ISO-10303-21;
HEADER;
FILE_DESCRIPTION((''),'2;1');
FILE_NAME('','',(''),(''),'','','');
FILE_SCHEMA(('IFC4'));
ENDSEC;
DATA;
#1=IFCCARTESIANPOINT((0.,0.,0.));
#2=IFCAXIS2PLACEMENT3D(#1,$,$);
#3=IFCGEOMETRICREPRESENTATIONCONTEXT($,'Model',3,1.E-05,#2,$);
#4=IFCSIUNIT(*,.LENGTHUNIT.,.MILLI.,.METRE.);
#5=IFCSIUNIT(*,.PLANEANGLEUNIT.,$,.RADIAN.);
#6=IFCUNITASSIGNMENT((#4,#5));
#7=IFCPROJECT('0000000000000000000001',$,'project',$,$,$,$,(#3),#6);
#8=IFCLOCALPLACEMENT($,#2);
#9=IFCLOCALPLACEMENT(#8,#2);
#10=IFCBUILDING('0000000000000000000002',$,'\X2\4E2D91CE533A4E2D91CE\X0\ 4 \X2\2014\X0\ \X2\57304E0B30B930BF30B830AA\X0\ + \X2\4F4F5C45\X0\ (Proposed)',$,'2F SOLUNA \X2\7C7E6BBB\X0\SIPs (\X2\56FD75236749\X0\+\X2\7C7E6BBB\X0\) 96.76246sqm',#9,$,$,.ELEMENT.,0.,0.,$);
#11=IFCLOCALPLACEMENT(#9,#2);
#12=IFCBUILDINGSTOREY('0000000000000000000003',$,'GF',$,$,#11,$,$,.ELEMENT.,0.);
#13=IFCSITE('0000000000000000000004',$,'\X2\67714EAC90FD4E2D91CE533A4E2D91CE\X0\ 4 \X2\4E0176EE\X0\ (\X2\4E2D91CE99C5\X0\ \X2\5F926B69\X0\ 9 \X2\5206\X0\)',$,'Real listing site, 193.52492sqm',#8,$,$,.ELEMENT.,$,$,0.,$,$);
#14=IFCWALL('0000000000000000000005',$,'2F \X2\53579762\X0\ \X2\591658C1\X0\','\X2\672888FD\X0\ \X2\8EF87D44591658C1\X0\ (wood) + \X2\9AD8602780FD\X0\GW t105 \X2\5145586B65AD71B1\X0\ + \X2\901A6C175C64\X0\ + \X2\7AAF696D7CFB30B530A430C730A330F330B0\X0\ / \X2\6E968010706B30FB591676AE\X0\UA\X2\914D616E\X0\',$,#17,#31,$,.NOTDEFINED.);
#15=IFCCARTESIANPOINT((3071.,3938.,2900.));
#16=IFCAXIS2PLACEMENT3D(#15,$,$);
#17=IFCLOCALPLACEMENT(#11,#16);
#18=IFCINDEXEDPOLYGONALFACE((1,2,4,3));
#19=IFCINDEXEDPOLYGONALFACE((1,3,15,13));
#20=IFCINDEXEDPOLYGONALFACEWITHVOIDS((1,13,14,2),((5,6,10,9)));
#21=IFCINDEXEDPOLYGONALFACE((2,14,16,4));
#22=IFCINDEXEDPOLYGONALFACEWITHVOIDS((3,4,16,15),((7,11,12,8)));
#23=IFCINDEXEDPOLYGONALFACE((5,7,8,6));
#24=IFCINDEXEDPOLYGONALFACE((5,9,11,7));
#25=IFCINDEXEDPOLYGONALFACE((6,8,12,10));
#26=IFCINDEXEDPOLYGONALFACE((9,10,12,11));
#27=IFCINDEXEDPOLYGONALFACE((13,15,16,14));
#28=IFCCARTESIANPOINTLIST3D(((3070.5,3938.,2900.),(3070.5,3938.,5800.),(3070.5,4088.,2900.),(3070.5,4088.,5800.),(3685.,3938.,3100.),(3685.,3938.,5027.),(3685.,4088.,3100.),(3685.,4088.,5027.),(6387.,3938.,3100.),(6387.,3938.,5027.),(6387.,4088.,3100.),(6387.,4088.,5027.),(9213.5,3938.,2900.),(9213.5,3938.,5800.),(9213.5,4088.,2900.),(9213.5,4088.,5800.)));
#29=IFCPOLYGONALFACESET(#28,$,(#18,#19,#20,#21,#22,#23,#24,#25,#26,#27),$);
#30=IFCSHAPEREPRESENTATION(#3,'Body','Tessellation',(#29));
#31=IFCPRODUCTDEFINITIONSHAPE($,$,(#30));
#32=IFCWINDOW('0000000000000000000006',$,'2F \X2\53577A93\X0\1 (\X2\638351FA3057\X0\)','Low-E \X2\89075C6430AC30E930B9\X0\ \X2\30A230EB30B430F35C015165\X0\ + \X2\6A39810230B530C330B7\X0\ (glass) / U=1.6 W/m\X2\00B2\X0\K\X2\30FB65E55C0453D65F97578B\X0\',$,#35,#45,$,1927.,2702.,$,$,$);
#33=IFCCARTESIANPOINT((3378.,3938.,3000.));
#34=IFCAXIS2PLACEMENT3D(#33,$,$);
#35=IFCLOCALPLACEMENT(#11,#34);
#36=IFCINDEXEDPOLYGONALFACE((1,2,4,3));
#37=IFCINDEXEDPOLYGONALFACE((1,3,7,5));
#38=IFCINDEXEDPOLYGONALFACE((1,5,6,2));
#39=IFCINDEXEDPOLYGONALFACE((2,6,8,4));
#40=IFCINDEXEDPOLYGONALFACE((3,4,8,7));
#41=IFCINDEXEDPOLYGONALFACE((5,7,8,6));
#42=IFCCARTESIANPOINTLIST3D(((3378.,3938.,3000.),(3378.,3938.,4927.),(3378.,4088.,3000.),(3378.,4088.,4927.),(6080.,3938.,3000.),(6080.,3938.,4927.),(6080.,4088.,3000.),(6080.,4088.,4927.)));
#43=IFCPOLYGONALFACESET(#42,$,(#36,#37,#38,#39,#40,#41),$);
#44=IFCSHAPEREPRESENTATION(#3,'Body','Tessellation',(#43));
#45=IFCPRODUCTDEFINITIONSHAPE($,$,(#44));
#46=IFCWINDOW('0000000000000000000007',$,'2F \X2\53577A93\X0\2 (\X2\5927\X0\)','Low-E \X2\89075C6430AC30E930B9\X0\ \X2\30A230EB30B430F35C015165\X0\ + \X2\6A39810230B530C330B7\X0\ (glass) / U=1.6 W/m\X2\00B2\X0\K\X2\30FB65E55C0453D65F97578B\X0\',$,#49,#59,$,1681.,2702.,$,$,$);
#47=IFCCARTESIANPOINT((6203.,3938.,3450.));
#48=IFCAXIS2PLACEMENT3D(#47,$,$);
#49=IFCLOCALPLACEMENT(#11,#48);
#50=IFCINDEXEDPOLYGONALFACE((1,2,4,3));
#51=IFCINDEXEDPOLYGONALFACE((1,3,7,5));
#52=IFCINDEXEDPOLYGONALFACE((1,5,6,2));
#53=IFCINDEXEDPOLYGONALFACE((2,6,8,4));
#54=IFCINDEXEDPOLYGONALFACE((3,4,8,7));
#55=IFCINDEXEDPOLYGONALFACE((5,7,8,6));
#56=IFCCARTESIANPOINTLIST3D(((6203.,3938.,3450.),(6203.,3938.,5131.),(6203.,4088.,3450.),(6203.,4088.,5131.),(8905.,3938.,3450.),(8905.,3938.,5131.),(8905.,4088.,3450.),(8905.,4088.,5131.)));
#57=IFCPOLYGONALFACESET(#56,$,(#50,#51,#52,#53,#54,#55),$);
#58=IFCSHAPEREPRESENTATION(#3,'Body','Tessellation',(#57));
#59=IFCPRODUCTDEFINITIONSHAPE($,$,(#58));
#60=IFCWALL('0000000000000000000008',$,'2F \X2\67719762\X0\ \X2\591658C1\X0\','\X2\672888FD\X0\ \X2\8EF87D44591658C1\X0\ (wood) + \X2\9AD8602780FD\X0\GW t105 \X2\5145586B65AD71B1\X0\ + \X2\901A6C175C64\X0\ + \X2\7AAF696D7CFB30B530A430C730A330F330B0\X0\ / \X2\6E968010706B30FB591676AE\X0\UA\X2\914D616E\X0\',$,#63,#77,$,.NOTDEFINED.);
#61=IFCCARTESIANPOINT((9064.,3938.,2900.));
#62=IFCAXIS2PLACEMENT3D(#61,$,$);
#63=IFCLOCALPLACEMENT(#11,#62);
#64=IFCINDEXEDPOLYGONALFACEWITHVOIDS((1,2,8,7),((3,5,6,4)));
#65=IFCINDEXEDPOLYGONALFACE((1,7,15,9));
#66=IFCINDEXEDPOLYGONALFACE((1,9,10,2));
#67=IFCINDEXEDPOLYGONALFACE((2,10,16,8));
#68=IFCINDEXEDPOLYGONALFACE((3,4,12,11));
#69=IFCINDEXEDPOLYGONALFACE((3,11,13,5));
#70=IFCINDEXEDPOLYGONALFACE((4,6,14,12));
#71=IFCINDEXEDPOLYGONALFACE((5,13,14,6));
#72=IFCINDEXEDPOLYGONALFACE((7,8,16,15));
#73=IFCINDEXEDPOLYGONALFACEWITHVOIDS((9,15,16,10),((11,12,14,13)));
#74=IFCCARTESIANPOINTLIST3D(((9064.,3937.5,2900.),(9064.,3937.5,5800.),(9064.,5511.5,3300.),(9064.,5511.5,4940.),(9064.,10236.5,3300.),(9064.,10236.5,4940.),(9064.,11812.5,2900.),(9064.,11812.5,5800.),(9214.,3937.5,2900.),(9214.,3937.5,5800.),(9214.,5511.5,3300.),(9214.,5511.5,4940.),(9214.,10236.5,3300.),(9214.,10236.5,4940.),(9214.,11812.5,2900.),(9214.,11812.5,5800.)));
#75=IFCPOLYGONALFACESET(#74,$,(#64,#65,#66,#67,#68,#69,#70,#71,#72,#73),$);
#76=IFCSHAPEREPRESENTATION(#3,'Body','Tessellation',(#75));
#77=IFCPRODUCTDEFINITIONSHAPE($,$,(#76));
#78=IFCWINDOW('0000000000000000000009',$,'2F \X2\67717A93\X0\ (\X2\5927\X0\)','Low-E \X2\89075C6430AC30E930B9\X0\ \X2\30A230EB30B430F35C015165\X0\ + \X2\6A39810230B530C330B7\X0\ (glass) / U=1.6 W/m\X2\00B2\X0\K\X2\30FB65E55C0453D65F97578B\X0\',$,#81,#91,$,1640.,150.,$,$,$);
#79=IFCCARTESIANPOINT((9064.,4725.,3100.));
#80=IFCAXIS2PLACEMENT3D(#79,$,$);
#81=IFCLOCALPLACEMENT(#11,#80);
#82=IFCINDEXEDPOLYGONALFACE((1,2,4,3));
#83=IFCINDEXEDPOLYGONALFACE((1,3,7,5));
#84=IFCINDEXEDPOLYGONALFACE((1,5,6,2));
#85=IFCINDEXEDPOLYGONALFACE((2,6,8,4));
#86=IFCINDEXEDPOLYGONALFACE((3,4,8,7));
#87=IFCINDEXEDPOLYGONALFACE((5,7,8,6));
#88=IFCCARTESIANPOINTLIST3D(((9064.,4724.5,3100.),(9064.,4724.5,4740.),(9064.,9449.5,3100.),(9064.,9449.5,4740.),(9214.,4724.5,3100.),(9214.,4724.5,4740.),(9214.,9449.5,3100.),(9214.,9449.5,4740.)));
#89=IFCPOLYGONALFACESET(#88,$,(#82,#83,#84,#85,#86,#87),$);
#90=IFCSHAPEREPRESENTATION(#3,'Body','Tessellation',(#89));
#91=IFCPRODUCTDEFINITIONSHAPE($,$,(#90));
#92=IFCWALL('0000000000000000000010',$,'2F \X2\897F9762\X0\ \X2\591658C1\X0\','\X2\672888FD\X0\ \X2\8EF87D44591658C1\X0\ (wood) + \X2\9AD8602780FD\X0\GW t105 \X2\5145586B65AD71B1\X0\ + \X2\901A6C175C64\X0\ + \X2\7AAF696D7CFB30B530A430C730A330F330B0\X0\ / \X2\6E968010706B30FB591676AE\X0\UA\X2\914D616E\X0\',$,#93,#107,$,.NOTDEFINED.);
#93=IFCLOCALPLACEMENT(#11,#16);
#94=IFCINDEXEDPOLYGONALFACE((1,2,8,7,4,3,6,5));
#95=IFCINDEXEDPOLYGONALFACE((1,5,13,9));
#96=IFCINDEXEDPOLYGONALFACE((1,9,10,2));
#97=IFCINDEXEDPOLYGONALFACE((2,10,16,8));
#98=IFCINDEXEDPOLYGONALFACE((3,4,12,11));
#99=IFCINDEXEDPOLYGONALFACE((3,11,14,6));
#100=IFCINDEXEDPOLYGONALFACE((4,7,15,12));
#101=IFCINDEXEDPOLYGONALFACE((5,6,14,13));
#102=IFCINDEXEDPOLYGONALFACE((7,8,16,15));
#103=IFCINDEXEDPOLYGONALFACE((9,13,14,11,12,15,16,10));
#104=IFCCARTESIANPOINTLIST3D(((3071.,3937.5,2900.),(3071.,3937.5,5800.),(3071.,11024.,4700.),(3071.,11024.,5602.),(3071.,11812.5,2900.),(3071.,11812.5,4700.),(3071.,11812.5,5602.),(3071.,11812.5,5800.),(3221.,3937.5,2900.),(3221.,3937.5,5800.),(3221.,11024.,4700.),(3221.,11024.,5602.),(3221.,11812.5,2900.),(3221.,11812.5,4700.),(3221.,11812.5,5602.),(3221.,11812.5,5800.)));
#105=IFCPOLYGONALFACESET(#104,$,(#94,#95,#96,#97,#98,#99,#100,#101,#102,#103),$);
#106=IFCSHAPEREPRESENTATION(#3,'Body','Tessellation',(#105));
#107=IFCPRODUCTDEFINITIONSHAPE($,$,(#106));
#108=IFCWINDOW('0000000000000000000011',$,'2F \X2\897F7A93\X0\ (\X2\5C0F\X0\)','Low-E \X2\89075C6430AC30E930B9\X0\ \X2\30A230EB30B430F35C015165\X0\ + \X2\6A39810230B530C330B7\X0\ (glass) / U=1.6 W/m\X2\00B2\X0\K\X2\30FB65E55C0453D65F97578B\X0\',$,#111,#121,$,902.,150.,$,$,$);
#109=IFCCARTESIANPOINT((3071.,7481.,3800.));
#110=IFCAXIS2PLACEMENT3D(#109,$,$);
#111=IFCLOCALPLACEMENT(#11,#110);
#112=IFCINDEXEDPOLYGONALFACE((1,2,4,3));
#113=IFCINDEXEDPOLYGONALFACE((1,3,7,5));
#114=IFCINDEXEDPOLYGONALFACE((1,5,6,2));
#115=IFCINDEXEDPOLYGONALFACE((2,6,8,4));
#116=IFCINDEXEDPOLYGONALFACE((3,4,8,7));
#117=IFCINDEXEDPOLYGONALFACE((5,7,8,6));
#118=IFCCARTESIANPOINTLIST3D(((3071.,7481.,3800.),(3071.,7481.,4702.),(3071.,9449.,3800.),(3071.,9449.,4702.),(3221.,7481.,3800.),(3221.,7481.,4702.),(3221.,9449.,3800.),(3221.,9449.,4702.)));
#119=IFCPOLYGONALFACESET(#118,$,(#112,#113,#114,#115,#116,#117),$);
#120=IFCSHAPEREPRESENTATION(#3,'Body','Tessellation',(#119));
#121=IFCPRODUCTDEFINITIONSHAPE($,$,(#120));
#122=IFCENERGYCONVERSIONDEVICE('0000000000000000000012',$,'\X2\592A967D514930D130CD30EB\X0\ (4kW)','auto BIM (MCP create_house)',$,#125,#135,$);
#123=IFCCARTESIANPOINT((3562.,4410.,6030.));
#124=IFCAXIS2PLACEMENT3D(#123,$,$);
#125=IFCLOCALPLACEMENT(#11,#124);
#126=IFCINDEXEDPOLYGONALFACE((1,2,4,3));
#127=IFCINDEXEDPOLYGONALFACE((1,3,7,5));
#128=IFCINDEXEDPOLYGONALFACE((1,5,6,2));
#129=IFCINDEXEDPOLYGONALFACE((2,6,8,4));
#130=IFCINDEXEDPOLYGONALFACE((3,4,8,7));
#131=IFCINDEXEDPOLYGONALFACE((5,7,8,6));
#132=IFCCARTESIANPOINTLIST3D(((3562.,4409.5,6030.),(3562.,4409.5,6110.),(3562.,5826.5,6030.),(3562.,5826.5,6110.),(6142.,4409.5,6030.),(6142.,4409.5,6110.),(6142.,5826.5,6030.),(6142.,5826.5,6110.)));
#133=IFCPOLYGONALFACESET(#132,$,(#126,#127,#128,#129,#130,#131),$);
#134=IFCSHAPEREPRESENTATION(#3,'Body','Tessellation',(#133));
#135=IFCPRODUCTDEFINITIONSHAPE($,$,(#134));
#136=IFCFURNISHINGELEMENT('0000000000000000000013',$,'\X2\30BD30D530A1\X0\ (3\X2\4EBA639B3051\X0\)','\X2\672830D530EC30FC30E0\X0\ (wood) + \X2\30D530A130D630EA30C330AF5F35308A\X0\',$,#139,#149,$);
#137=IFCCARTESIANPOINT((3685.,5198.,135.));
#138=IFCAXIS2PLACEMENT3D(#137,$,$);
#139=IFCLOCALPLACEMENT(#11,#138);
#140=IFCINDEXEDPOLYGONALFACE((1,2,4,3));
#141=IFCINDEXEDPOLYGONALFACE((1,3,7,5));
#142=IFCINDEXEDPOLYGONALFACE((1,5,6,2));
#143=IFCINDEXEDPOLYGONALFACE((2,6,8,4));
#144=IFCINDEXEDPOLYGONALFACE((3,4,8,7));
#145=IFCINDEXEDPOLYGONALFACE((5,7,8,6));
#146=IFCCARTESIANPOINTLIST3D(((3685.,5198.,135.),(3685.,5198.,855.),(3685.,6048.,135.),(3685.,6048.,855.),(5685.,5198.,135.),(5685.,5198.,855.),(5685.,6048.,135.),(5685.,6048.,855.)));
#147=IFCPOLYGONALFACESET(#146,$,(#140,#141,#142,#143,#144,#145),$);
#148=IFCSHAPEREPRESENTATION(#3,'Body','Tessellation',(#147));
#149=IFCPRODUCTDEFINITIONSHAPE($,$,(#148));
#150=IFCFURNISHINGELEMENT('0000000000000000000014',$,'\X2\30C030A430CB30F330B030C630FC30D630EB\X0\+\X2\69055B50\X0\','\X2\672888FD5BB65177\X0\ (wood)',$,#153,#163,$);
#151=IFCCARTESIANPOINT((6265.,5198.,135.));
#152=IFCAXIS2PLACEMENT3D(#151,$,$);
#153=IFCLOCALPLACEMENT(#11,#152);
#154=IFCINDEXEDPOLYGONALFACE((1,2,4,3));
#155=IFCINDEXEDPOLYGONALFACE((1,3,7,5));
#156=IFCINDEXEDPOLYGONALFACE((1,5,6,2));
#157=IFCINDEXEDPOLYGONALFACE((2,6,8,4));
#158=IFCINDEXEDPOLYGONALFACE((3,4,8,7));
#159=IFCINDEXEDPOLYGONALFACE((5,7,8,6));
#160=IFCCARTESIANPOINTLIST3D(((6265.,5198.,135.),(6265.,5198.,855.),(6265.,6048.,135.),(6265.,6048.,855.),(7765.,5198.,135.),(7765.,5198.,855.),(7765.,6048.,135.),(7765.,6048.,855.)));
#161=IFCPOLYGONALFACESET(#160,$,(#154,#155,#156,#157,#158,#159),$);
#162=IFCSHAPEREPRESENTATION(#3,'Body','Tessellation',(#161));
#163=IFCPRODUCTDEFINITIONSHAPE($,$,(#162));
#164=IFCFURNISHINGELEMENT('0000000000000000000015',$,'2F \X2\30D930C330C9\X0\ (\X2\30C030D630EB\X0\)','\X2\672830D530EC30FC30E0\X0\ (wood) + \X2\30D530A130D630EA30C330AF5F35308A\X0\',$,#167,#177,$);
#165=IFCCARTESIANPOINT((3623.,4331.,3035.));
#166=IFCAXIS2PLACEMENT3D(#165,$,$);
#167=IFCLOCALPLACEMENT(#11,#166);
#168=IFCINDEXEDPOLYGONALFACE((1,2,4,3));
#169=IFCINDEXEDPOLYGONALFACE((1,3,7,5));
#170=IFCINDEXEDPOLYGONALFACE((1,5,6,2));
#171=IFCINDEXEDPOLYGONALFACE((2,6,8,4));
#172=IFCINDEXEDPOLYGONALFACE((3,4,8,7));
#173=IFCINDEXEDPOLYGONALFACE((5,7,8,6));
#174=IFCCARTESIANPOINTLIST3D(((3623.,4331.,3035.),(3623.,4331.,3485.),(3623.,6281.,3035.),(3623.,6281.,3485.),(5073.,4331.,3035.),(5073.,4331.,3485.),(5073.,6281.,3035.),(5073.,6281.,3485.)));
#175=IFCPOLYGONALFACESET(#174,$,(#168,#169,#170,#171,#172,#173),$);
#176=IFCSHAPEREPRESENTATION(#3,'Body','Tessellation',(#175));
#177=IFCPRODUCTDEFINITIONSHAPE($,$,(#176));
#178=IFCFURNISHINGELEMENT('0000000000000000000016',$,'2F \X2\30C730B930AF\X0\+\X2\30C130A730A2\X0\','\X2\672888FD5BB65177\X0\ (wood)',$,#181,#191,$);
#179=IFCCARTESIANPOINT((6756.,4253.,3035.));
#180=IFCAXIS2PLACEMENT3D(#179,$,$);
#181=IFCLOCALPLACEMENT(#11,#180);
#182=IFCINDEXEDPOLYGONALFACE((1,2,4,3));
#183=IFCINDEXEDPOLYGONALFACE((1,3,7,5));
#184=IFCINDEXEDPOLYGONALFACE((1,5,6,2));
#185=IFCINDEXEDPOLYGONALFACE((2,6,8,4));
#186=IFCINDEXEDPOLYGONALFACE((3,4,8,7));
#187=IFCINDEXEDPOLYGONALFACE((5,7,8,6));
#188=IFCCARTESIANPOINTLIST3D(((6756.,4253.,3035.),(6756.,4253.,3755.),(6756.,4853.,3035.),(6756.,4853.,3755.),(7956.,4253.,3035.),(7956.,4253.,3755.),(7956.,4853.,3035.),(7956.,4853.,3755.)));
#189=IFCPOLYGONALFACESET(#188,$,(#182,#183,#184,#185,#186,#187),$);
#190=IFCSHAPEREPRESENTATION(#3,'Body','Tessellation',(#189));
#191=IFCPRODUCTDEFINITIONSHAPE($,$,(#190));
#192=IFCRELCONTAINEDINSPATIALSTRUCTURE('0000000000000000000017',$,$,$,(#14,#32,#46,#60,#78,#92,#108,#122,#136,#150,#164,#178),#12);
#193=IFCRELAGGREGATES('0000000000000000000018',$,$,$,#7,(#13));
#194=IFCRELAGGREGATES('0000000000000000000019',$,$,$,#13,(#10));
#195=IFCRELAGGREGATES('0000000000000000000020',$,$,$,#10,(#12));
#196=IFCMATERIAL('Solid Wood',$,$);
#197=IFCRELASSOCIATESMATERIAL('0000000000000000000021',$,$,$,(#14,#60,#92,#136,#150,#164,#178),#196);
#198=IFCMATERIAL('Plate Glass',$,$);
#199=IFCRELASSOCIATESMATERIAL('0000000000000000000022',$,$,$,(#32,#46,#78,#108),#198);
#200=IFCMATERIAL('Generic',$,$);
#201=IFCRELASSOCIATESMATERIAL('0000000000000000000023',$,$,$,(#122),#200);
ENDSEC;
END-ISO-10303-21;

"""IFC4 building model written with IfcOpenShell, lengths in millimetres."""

from ifc_helpers import new_model, si_unit, frame, frame_2d, origin, place, context, project, spatial, rectangle, extrude, material, element, fill, save


model = new_model("IFC4")

# Units and contexts
model_context = context("Model", 3, precision=1e-05, world=origin())
ifc_project = project(units=[si_unit("LENGTHUNIT", "METRE", prefix="MILLI"), si_unit("PLANEANGLEUNIT", "RADIAN")], contexts=[model_context])

# Site, building, storey
site_placement = place(None, origin())
site = spatial("IfcSite", under=ifc_project, at=site_placement, Name="東京都中野区中野 4 丁目 (中野駅 徒歩 9 分)", ObjectType="Real listing site, 193.52492sqm", CompositionType="ELEMENT", RefElevation=0.0)
building_placement = place(site_placement, origin())
building = spatial("IfcBuilding", under=site, at=building_placement, Name="中野区中野 4 — 地下スタジオ + 住居 (Proposed)", ObjectType="2F SOLUNA 籾殻SIPs (国産杉+籾殻) 96.76246sqm", CompositionType="ELEMENT", ElevationOfRefHeight=0.0, ElevationOfTerrain=0.0)
storey_placement = place(building_placement, origin())
storey = spatial("IfcBuildingStorey", under=building, at=storey_placement, Name="GF", CompositionType="ELEMENT", Elevation=0.0)

# Shared definitions
ifc_material_1 = material(Name="Solid Wood")

# Wall, openings, windows
wall_1_placement = place(storey_placement, frame((3071.0, 3938.0, 2900.0)))
wall_1 = element("IfcWall", 1, at=wall_1_placement, inside=storey, material=ifc_material_1, Name="2F 南面 外壁", Description="木製 軸組外壁 (wood) + 高性能GW t105 充填断熱 + 通気層 + 窯業系サイディング / 準耐火・外皮UA配慮", PredefinedType="NOTDEFINED", context=model_context, shape_type="SweptSolid", body=[
    extrude(rectangle(XDim=6143.0, YDim=150.0, at=frame_2d((3071.0, 75.0))), frame((3071.0, 3938.0, 2900.0)), (0.0, 0.0, 1.0), 2900.0),
])
opening_1_placement = place(storey_placement, frame((3378.0, 3938.0, 3000.0)))
opening_1 = element("IfcOpeningElement", 2, at=opening_1_placement, cuts=wall_1, PredefinedType="NOTDEFINED", context=model_context, shape_type="SweptSolid", body=[
    extrude(rectangle(XDim=2702.0, YDim=150.0, at=frame_2d((1351.0, 75.0))), frame((3378.0, 3938.0, 3000.0)), (0.0, 0.0, 1.0), 1927.0),
])
opening_2_placement = place(storey_placement, frame((6203.0, 3938.0, 3450.0)))
opening_2 = element("IfcOpeningElement", 3, at=opening_2_placement, cuts=wall_1, PredefinedType="NOTDEFINED", context=model_context, shape_type="SweptSolid", body=[
    extrude(rectangle(XDim=2702.0, YDim=150.0, at=frame_2d((1351.0, 75.0))), frame((6203.0, 3938.0, 3450.0)), (0.0, 0.0, 1.0), 1681.0),
])
ifc_material_2 = material(Name="Plate Glass")
window_1_placement = place(storey_placement, frame((3378.0, 3938.0, 3000.0)))
window_1 = element("IfcWindow", 4, at=window_1_placement, inside=storey, material=ifc_material_2, Name="2F 南窓1 (掃出し)", Description="Low-E 複層ガラス アルゴン封入 + 樹脂サッシ (glass) / U=1.6 W/m²K・日射取得型", OverallHeight=1927.0, OverallWidth=2702.0, context=model_context, shape_type="SweptSolid", body=[
    extrude(rectangle(XDim=2702.0, YDim=150.0, at=frame_2d((1351.0, 75.0))), frame((3378.0, 3938.0, 3000.0)), (0.0, 0.0, 1.0), 1927.0),
])
fill(opening_1, window_1)
window_2_placement = place(storey_placement, frame((6203.0, 3938.0, 3450.0)))
window_2 = element("IfcWindow", 5, at=window_2_placement, inside=storey, material=ifc_material_2, Name="2F 南窓2 (大)", Description="Low-E 複層ガラス アルゴン封入 + 樹脂サッシ (glass) / U=1.6 W/m²K・日射取得型", OverallHeight=1681.0, OverallWidth=2702.0, context=model_context, shape_type="SweptSolid", body=[
    extrude(rectangle(XDim=2702.0, YDim=150.0, at=frame_2d((1351.0, 75.0))), frame((6203.0, 3938.0, 3450.0)), (0.0, 0.0, 1.0), 1681.0),
])
fill(opening_2, window_2)

# Walls, openings, windows
wall_2_placement = place(storey_placement, frame((9064.0, 3938.0, 2900.0)))
wall_2 = element("IfcWall", 6, at=wall_2_placement, inside=storey, material=ifc_material_1, Name="2F 東面 外壁", Description="木製 軸組外壁 (wood) + 高性能GW t105 充填断熱 + 通気層 + 窯業系サイディング / 準耐火・外皮UA配慮", PredefinedType="NOTDEFINED", context=model_context, shape_type="SweptSolid", body=[
    extrude(rectangle(XDim=150.0, YDim=7875.0, at=frame_2d((75.0, 3937.0))), frame((9064.0, 3938.0, 2900.0)), (0.0, 0.0, 1.0), 2900.0),
])
opening_3_placement = place(storey_placement, frame((9064.0, 4725.0, 3100.0)))
opening_3 = element("IfcOpeningElement", 7, at=opening_3_placement, cuts=wall_2, PredefinedType="NOTDEFINED", context=model_context, shape_type="SweptSolid", body=[
    extrude(rectangle(XDim=150.0, YDim=4725.0, at=frame_2d((75.0, 2362.0))), frame((9064.0, 4725.0, 3100.0)), (0.0, 0.0, 1.0), 1640.0),
])
window_3_placement = place(storey_placement, frame((9064.0, 4725.0, 3100.0)))
window_3 = element("IfcWindow", 8, at=window_3_placement, inside=storey, material=ifc_material_2, Name="2F 東窓 (大)", Description="Low-E 複層ガラス アルゴン封入 + 樹脂サッシ (glass) / U=1.6 W/m²K・日射取得型", OverallHeight=1640.0, OverallWidth=150.0, context=model_context, shape_type="SweptSolid", body=[
    extrude(rectangle(XDim=150.0, YDim=4725.0, at=frame_2d((75.0, 2362.0))), frame((9064.0, 4725.0, 3100.0)), (0.0, 0.0, 1.0), 1640.0),
])
fill(opening_3, window_3)
wall_3_placement = place(storey_placement, frame((3071.0, 3938.0, 2900.0)))
wall_3 = element("IfcWall", 9, at=wall_3_placement, inside=storey, material=ifc_material_1, Name="2F 西面 外壁", Description="木製 軸組外壁 (wood) + 高性能GW t105 充填断熱 + 通気層 + 窯業系サイディング / 準耐火・外皮UA配慮", PredefinedType="NOTDEFINED", context=model_context, shape_type="SweptSolid", body=[
    extrude(rectangle(XDim=150.0, YDim=7875.0, at=frame_2d((75.0, 3937.0))), frame((3071.0, 3938.0, 2900.0)), (0.0, 0.0, 1.0), 2900.0),
])
opening_4_placement = place(storey_placement, frame((3071.0, 7481.0, 3800.0)))
opening_4 = element("IfcOpeningElement", 10, at=opening_4_placement, cuts=wall_3, PredefinedType="NOTDEFINED", context=model_context, shape_type="SweptSolid", body=[
    extrude(rectangle(XDim=150.0, YDim=1968.0, at=frame_2d((75.0, 984.0))), frame((3071.0, 7481.0, 3800.0)), (0.0, 0.0, 1.0), 902.0),
])
window_4_placement = place(storey_placement, frame((3071.0, 7481.0, 3800.0)))
window_4 = element("IfcWindow", 11, at=window_4_placement, inside=storey, material=ifc_material_2, Name="2F 西窓 (小)", Description="Low-E 複層ガラス アルゴン封入 + 樹脂サッシ (glass) / U=1.6 W/m²K・日射取得型", OverallHeight=902.0, OverallWidth=150.0, context=model_context, shape_type="SweptSolid", body=[
    extrude(rectangle(XDim=150.0, YDim=1968.0, at=frame_2d((75.0, 984.0))), frame((3071.0, 7481.0, 3800.0)), (0.0, 0.0, 1.0), 902.0),
])
fill(opening_4, window_4)

# Shared definitions
ifc_material_3 = material(Name="Generic")

# Energy conversion device
energy_conversion_device_placement = place(storey_placement, frame((3562.0, 4410.0, 6030.0)))
element("IfcEnergyConversionDevice", 12, at=energy_conversion_device_placement, inside=storey, material=ifc_material_3, Name="太陽光パネル (4kW)", Description="auto BIM (MCP create_house)", context=model_context, shape_type="SweptSolid", body=[
    extrude(rectangle(XDim=2580.0, YDim=1417.0, at=frame_2d((1290.0, 708.0))), frame((3562.0, 4410.0, 6030.0)), (0.0, 0.0, 1.0), 80.0),
])

# Furnishing elements
furnishing_1_placement = place(storey_placement, frame((3685.0, 5198.0, 135.0)))
element("IfcFurnishingElement", 13, at=furnishing_1_placement, inside=storey, material=ifc_material_1, Name="ソファ (3人掛け)", Description="木フレーム (wood) + ファブリック張り", context=model_context, shape_type="SweptSolid", body=[
    extrude(rectangle(XDim=2000.0, YDim=850.0, at=frame_2d((1000.0, 425.0))), frame((3685.0, 5198.0, 135.0)), (0.0, 0.0, 1.0), 720.0),
])
furnishing_2_placement = place(storey_placement, frame((6265.0, 5198.0, 135.0)))
element("IfcFurnishingElement", 14, at=furnishing_2_placement, inside=storey, material=ifc_material_1, Name="ダイニングテーブル+椅子", Description="木製家具 (wood)", context=model_context, shape_type="SweptSolid", body=[
    extrude(rectangle(XDim=1500.0, YDim=850.0, at=frame_2d((750.0, 425.0))), frame((6265.0, 5198.0, 135.0)), (0.0, 0.0, 1.0), 720.0),
])
furnishing_3_placement = place(storey_placement, frame((3623.0, 4331.0, 3035.0)))
element("IfcFurnishingElement", 15, at=furnishing_3_placement, inside=storey, material=ifc_material_1, Name="2F ベッド (ダブル)", Description="木フレーム (wood) + ファブリック張り", context=model_context, shape_type="SweptSolid", body=[
    extrude(rectangle(XDim=1450.0, YDim=1950.0, at=frame_2d((725.0, 975.0))), frame((3623.0, 4331.0, 3035.0)), (0.0, 0.0, 1.0), 450.0),
])
furnishing_4_placement = place(storey_placement, frame((6756.0, 4253.0, 3035.0)))
element("IfcFurnishingElement", 16, at=furnishing_4_placement, inside=storey, material=ifc_material_1, Name="2F デスク+チェア", Description="木製家具 (wood)", context=model_context, shape_type="SweptSolid", body=[
    extrude(rectangle(XDim=1200.0, YDim=600.0, at=frame_2d((600.0, 300.0))), frame((6756.0, 4253.0, 3035.0)), (0.0, 0.0, 1.0), 720.0),
])

save(model, "model.ifc")
